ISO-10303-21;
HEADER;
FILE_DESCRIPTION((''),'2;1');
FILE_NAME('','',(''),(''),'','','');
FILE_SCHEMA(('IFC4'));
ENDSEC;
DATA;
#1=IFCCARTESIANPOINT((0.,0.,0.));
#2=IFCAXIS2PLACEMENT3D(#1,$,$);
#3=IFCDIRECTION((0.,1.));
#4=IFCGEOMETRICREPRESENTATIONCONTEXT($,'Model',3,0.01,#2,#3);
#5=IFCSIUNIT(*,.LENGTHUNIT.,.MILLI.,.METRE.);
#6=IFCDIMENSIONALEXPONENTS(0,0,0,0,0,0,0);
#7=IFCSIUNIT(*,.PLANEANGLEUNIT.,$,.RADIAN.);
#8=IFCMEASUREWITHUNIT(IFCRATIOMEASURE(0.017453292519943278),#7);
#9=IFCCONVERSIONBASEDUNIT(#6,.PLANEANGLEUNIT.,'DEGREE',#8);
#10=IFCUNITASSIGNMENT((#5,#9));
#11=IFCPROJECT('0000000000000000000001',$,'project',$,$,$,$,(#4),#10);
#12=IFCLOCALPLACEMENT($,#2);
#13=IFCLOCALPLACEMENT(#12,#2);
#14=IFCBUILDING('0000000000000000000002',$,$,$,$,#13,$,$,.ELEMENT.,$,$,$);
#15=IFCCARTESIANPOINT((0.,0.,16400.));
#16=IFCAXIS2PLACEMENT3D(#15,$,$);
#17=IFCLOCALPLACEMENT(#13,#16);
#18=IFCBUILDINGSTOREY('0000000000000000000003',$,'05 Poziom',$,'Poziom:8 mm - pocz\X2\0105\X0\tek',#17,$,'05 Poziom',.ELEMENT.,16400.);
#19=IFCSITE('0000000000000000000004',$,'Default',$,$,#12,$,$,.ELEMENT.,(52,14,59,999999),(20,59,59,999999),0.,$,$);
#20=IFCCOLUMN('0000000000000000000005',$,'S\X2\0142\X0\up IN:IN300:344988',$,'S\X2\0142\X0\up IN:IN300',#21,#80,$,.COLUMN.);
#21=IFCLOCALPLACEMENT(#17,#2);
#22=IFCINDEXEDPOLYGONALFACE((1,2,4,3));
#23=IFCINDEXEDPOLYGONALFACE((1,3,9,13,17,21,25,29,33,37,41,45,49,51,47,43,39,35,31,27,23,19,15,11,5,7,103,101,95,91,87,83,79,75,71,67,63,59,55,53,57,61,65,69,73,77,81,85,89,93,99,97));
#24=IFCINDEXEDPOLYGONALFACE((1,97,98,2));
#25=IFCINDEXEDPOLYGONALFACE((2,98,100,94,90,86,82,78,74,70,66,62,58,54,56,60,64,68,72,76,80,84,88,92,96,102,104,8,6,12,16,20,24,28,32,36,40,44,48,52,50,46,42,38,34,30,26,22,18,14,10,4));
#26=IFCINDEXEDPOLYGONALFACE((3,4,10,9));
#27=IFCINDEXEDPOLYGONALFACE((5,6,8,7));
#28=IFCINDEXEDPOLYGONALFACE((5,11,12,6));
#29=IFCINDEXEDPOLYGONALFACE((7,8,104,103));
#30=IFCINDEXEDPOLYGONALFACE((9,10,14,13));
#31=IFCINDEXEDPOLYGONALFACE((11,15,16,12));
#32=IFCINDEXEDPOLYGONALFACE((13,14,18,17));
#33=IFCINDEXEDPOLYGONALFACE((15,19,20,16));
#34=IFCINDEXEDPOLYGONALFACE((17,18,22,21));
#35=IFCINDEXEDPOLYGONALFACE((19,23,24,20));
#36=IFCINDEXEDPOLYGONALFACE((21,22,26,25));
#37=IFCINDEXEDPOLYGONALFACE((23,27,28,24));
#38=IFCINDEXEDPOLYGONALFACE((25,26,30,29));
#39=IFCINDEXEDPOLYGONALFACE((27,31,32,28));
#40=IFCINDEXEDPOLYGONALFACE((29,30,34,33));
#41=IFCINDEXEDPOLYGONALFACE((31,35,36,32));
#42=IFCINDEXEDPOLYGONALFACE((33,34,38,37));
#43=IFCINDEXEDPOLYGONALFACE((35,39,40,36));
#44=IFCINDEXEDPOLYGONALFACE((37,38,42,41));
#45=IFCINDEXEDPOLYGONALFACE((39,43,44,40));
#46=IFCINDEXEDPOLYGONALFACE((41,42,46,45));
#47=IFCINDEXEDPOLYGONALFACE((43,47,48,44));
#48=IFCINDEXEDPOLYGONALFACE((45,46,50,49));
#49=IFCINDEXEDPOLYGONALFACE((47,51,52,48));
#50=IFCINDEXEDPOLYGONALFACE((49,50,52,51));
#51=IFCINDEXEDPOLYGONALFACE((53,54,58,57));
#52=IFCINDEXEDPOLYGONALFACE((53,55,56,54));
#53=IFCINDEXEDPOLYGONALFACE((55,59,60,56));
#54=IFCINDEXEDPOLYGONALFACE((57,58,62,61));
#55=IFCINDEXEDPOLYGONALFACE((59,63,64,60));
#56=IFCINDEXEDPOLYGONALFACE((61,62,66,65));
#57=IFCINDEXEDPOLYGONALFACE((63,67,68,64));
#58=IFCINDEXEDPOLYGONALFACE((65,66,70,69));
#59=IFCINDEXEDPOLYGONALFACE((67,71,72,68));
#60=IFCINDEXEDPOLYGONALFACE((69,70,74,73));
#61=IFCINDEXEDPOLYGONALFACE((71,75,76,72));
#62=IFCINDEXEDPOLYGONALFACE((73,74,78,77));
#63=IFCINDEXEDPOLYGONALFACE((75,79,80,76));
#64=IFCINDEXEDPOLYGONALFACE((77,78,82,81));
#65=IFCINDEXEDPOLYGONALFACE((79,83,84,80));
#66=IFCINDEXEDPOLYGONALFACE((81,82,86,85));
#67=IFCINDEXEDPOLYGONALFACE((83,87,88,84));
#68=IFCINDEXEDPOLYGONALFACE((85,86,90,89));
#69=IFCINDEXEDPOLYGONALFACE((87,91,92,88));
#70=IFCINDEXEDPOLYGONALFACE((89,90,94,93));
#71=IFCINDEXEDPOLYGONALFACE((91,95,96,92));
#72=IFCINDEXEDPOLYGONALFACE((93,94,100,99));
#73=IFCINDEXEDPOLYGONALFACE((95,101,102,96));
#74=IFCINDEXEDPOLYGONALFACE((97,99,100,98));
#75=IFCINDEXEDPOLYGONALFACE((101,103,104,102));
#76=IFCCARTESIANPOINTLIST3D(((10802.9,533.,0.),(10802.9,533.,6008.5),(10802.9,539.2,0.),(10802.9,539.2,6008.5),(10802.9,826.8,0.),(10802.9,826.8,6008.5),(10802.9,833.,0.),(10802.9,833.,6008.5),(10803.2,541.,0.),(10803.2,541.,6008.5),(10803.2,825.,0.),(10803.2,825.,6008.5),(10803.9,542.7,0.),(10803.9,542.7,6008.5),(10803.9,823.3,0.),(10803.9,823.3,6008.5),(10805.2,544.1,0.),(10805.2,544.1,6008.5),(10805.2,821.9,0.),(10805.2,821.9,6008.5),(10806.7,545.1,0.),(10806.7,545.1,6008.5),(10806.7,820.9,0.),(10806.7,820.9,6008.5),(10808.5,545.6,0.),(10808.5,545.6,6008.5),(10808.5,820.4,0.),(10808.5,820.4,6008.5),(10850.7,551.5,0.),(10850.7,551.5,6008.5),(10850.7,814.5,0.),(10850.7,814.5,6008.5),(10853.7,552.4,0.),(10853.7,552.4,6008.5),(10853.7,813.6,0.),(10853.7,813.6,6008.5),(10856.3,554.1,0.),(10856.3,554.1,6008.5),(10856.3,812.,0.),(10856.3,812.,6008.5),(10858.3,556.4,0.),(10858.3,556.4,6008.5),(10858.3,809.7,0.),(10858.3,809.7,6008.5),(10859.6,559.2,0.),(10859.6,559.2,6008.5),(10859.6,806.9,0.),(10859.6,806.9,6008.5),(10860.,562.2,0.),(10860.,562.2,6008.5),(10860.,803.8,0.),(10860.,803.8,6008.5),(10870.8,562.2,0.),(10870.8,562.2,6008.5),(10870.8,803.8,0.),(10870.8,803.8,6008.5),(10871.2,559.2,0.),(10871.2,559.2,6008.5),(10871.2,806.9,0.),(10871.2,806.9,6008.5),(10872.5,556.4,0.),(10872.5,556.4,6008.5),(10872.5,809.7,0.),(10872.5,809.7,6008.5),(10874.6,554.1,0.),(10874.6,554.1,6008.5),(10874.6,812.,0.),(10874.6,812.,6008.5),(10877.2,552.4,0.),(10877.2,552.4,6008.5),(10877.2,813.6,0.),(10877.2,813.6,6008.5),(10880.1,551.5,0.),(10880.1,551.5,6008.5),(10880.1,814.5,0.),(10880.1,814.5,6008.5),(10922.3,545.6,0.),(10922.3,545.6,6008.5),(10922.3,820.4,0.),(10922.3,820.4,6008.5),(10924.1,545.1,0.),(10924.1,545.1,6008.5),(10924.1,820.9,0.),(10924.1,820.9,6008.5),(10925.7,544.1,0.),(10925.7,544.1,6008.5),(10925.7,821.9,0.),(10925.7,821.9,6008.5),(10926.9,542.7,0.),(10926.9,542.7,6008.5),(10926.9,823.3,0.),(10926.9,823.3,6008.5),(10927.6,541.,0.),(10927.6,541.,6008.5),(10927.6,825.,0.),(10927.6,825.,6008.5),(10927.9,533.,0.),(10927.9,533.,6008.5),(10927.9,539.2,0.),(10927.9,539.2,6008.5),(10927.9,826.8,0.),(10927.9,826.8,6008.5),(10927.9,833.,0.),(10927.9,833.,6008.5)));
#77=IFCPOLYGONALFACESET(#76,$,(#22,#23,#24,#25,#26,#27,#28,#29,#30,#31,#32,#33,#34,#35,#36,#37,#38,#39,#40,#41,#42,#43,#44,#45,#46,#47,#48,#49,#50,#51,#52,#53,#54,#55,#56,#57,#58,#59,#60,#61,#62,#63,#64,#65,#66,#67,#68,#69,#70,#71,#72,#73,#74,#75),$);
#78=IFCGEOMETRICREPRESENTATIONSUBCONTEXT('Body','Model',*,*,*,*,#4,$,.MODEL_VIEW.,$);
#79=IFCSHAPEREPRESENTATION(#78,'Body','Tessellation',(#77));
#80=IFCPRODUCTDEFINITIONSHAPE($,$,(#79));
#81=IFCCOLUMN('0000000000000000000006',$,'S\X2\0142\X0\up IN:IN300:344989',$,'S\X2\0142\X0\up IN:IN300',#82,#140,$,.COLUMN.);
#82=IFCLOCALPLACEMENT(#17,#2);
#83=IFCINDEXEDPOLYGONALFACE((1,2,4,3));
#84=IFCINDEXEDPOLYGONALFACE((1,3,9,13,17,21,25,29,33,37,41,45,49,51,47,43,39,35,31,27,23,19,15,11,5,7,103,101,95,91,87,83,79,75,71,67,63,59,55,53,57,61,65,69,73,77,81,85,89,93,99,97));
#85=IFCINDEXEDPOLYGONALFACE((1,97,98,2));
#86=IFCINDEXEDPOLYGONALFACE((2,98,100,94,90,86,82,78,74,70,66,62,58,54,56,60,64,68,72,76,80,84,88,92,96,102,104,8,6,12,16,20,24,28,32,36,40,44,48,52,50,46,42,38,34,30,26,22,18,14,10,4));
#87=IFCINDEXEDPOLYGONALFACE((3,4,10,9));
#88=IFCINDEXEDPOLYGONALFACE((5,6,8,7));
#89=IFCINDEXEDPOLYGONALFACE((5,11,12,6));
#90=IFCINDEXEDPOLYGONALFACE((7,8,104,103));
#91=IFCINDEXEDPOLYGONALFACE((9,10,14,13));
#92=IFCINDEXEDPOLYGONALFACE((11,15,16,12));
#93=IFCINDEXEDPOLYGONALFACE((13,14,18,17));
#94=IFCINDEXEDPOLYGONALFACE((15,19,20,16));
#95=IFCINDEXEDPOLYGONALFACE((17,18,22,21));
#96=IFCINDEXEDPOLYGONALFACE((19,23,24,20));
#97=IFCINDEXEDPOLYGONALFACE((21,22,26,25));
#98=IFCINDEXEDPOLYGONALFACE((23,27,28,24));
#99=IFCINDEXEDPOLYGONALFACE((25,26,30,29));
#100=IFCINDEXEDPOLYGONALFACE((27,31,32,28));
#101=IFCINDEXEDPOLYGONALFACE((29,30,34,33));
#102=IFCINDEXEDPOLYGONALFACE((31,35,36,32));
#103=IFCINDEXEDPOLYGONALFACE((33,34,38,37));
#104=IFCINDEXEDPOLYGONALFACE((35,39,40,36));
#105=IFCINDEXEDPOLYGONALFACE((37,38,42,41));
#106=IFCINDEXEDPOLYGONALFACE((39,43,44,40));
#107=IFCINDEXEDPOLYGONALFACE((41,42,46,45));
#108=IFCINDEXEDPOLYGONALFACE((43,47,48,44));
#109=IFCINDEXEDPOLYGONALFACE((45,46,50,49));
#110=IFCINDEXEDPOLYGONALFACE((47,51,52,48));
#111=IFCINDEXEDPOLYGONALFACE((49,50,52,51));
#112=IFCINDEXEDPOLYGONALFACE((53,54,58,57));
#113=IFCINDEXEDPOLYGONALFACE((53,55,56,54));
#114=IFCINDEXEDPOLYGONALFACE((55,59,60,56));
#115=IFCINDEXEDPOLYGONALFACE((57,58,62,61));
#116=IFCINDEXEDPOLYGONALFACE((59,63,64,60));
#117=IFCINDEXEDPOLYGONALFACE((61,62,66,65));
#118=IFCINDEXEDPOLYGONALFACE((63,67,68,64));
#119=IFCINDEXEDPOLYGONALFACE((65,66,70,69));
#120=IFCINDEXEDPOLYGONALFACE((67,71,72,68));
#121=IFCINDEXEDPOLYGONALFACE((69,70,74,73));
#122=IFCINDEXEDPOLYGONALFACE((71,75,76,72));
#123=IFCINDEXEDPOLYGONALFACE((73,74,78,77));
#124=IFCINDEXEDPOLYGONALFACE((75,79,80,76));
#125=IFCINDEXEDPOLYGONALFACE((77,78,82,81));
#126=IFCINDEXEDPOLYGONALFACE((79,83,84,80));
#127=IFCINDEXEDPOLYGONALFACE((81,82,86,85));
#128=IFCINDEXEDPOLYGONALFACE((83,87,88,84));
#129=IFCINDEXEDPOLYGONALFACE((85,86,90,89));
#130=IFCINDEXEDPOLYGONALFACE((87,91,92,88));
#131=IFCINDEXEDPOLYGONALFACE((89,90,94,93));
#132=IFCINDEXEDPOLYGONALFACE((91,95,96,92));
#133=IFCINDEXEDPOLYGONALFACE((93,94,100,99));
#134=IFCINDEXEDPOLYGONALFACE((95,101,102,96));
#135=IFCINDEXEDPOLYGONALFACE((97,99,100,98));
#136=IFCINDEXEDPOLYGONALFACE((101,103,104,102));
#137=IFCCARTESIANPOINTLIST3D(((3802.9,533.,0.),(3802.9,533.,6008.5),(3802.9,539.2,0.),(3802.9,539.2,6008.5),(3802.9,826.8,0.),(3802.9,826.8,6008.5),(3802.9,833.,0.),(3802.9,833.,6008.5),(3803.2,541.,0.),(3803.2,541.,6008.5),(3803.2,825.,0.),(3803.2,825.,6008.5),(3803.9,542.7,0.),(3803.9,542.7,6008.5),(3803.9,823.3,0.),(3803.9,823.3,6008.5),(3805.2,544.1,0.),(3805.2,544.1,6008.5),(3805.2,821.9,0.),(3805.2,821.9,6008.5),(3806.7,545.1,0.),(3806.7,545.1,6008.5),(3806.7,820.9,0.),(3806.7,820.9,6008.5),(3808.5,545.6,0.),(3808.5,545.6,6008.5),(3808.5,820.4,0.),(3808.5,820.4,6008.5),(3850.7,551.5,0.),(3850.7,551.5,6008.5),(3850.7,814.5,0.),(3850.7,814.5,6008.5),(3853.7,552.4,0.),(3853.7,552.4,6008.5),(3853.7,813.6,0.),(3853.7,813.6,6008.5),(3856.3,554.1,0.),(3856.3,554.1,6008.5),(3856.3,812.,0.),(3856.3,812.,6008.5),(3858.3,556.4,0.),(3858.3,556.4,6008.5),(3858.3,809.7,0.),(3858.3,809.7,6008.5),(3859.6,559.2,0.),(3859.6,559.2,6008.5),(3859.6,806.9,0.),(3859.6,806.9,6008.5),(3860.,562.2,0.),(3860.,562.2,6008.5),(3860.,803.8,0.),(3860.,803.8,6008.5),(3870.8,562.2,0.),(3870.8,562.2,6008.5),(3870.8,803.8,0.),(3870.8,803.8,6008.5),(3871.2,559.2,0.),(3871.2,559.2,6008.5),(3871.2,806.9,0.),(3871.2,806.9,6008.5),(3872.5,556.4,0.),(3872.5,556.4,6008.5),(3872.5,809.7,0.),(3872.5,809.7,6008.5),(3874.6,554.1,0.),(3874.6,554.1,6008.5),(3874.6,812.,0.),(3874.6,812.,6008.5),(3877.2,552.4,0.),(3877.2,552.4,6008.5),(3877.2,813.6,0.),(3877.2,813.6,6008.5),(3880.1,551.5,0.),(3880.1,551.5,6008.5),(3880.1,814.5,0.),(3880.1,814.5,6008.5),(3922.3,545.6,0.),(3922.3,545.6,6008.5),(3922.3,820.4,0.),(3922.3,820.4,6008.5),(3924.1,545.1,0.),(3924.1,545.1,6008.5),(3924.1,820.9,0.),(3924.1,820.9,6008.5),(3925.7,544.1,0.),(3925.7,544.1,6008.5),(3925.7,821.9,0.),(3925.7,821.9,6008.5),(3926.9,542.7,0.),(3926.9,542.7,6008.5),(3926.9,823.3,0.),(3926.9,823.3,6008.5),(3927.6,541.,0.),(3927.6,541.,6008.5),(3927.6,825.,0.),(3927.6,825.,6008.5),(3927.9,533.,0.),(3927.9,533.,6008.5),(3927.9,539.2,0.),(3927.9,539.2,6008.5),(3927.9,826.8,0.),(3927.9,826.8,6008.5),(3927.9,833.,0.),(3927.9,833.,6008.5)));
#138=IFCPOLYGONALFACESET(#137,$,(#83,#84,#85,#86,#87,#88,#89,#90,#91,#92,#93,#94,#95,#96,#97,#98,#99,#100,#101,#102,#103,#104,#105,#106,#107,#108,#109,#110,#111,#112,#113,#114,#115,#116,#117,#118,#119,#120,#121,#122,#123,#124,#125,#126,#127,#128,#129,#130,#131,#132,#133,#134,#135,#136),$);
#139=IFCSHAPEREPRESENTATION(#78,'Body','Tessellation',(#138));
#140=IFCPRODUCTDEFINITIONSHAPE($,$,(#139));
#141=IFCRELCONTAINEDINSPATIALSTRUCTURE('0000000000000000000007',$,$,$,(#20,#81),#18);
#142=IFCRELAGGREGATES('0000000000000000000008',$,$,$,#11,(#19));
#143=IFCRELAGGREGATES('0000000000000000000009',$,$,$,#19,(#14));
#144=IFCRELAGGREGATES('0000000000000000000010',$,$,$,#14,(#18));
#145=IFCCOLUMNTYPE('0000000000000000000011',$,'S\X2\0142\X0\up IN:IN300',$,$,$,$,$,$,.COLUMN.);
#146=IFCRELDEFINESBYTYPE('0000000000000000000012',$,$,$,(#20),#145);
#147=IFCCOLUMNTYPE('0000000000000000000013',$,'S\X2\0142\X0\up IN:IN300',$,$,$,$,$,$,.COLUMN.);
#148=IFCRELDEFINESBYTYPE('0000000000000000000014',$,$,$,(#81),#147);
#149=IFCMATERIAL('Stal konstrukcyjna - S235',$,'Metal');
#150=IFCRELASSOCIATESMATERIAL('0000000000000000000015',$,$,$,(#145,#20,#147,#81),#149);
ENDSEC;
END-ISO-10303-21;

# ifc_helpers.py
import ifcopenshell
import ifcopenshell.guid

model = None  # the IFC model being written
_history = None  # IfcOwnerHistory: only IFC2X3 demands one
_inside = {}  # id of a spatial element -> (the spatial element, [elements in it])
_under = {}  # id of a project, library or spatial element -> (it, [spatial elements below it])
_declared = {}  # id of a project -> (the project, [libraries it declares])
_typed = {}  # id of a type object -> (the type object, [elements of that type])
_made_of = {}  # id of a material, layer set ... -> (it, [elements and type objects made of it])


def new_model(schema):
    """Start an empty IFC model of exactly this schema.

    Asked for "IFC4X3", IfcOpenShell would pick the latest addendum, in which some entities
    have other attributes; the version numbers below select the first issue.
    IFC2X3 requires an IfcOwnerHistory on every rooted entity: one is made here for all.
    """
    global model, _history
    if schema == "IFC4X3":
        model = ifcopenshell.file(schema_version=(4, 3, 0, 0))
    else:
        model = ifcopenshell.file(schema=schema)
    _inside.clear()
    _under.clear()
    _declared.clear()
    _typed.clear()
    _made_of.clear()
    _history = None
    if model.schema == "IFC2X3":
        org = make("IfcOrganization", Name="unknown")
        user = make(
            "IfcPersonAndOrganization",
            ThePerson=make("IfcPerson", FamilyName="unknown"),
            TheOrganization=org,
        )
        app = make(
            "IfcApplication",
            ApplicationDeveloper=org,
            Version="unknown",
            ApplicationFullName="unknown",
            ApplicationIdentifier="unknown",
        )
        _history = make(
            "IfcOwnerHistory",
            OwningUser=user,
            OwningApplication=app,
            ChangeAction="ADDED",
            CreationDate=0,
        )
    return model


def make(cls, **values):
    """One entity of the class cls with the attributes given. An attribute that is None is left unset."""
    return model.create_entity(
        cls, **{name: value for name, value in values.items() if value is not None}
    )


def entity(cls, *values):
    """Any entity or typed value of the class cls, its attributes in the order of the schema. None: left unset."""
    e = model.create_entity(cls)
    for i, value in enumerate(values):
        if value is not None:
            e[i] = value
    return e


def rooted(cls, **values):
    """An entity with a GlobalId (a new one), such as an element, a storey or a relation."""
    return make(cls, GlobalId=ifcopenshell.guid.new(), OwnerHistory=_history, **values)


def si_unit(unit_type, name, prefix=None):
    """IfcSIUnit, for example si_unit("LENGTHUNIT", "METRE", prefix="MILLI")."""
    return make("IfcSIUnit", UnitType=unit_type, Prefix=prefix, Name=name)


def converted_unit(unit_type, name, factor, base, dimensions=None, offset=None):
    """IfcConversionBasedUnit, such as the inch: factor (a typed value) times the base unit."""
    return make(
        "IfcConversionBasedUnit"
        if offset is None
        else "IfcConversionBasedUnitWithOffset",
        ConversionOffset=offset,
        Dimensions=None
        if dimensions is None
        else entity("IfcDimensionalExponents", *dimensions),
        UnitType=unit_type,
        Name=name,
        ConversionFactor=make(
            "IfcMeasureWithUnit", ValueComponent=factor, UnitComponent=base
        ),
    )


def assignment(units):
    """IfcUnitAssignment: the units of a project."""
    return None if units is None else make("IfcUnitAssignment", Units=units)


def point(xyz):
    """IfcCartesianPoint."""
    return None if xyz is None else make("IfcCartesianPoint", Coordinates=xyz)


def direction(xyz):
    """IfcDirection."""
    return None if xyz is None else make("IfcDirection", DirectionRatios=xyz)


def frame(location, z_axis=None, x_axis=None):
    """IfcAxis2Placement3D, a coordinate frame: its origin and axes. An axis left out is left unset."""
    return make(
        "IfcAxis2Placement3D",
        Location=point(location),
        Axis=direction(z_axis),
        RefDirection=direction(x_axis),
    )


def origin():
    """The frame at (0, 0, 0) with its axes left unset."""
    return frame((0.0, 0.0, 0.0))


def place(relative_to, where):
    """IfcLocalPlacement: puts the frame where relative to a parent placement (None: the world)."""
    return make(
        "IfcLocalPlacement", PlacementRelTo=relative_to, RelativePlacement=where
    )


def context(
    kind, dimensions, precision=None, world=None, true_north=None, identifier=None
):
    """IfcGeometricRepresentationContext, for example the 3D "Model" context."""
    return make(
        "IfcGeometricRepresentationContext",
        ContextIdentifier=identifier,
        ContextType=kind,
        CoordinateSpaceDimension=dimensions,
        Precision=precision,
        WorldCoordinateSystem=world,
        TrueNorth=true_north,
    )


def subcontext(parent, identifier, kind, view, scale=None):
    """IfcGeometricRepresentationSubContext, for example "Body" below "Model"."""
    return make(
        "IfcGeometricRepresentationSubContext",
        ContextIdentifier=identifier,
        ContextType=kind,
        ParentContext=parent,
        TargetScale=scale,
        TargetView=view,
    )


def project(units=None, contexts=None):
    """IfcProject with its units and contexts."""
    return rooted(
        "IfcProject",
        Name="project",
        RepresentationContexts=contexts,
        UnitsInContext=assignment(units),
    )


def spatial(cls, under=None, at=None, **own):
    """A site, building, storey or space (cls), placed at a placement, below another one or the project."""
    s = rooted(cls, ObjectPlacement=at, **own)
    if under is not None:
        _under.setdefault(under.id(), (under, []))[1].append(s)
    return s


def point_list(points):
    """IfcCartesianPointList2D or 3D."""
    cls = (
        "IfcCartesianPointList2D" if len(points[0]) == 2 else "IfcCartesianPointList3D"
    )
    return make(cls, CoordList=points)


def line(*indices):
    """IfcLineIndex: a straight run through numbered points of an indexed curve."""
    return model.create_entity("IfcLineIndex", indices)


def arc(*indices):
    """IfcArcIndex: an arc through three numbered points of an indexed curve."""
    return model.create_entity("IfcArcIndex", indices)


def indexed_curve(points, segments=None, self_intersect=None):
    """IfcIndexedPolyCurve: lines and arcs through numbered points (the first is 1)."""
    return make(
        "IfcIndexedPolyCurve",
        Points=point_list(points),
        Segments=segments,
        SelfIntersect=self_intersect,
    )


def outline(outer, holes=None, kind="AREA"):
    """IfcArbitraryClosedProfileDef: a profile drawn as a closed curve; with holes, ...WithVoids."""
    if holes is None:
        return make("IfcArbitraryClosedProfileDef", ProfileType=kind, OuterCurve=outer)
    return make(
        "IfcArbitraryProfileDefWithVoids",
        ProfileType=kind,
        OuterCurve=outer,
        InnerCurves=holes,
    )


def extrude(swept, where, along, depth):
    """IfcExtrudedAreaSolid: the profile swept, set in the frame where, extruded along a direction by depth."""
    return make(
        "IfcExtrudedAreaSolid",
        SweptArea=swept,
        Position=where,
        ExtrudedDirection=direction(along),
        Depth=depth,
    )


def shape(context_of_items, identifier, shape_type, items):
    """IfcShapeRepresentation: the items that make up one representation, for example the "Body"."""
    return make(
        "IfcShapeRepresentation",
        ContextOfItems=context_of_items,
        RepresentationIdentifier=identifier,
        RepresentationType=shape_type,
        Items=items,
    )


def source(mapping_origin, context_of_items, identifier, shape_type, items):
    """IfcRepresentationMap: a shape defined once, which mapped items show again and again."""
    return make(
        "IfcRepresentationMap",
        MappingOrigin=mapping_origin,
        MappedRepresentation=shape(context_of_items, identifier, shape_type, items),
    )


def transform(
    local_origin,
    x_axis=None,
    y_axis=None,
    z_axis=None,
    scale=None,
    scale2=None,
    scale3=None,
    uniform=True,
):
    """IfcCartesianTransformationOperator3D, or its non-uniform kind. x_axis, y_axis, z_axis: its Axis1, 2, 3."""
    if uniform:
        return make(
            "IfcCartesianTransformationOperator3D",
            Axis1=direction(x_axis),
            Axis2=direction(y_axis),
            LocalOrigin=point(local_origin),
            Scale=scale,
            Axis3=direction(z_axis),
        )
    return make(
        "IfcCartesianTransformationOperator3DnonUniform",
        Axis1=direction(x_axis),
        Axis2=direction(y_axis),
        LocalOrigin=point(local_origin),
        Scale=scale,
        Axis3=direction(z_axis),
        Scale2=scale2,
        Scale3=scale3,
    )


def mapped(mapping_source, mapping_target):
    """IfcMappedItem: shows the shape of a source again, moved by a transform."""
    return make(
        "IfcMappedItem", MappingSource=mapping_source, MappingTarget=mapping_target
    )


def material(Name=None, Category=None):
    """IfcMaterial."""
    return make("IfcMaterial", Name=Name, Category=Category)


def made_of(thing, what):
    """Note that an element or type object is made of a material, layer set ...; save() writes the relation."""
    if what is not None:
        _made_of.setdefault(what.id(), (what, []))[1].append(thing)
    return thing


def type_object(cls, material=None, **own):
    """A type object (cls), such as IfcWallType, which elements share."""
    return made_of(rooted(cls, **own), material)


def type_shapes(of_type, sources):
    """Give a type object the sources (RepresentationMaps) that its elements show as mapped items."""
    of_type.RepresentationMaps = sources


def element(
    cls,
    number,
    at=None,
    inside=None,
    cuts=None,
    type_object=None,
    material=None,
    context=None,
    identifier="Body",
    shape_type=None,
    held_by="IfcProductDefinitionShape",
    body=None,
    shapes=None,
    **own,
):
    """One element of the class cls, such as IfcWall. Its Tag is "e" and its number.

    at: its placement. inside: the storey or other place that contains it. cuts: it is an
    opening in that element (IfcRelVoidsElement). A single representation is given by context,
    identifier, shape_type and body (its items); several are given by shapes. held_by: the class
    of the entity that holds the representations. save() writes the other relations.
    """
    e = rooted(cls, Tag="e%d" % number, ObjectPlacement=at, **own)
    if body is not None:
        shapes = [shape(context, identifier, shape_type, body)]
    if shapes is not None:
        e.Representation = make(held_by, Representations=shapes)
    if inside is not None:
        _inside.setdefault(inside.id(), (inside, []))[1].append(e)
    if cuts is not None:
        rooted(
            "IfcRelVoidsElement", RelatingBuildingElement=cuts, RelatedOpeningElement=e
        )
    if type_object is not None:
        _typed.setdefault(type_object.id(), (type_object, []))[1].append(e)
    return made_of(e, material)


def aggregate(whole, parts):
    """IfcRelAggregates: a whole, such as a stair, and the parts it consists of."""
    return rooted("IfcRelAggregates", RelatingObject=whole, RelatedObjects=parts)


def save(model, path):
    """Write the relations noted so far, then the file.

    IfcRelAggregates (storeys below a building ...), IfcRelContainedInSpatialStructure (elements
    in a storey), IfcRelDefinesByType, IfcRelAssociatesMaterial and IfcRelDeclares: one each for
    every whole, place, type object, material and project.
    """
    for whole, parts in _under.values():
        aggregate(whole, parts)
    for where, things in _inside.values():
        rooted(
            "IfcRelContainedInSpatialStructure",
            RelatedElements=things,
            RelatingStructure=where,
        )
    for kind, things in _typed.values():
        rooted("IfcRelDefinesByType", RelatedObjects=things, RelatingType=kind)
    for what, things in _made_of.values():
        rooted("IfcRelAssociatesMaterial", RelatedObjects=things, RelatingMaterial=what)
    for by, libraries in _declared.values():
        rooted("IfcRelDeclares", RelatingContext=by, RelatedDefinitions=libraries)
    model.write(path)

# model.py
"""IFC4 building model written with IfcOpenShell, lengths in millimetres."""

from ifc_helpers import new_model, entity, si_unit, converted_unit, direction, frame, origin, place, context, subcontext, project, spatial, line, arc, indexed_curve, outline, extrude, source, transform, mapped, material, type_object, type_shapes, element, save


model = new_model("IFC4")

# Units and contexts
model_context = context("Model", 3, precision=0.01, world=origin(), true_north=direction((0.0, 1.0)))
body_context = subcontext(model_context, "Body", "Model", "MODEL_VIEW")
ifc_project = project(units=[si_unit("LENGTHUNIT", "METRE", prefix="MILLI"), converted_unit("PLANEANGLEUNIT", "DEGREE", entity("IfcRatioMeasure", 0.017453292519943278), si_unit("PLANEANGLEUNIT", "RADIAN"), dimensions=[0, 0, 0, 0, 0, 0, 0])], contexts=[model_context])

# Site, building, storey
site_placement = place(None, origin())
site = spatial("IfcSite", under=ifc_project, at=site_placement, Name="Default", CompositionType="ELEMENT", RefLatitude=(52, 14, 59, 999999), RefLongitude=(20, 59, 59, 999999), RefElevation=0.0)
building_placement = place(site_placement, origin())
building = spatial("IfcBuilding", under=site, at=building_placement, CompositionType="ELEMENT")
storey_placement = place(building_placement, frame((0.0, 0.0, 16400.0)))
storey = spatial("IfcBuildingStorey", under=building, at=storey_placement, Name="05 Poziom", ObjectType="Poziom:8 mm - początek", LongName="05 Poziom", CompositionType="ELEMENT", Elevation=16400.0)

# Columns
ifc_material = material(Name="Stal konstrukcyjna - S235", Category="Metal")
column_type_1 = type_object("IfcColumnType", Name="Słup IN:IN300", PredefinedType="COLUMN", material=ifc_material)
shared_shape_1 = source(origin(), body_context, "Body", "SweptSolid", [
    extrude(outline(indexed_curve([(143.8, -62.5), (150.0, -62.5), (150.0, 62.5), (143.8, 62.5), (139.6, 60.9), (137.4, 56.9), (131.5, 14.7), (127.9, 8.1), (120.8, 5.4), (-120.8, 5.4), (-127.9, 8.1), (-131.5, 14.7), (-137.4, 56.9), (-139.6, 60.9), (-143.8, 62.5), (-150.0, 62.5), (-150.0, -62.5), (-143.8, -62.5), (-139.6, -60.9), (-137.4, -56.9), (-131.5, -14.7), (-127.9, -8.1), (-120.8, -5.4), (120.8, -5.4), (127.9, -8.1), (131.5, -14.7), (137.4, -56.9), (139.6, -60.9)], segments=[line(1, 2, 3, 4), arc(4, 5, 6), line(6, 7), arc(7, 8, 9), line(9, 10), arc(10, 11, 12), line(12, 13), arc(13, 14, 15), line(15, 16, 17, 18), arc(18, 19, 20), line(20, 21), arc(21, 22, 23), line(23, 24), arc(24, 25, 26), line(26, 27), arc(27, 28, 1)], self_intersect=False)), frame((10865.4, 683.0, 16400.0), z_axis=(0.0, 0.0, 1.0), x_axis=(0.0, -1.0, 0.0)), (0.0, 0.0, 1.0), 6008.5),
])
type_shapes(column_type_1, [shared_shape_1])
column_1_placement = place(storey_placement, frame((0.0, 0.0, -16400.0)))
element("IfcColumn", 1, at=column_1_placement, inside=storey, type_object=column_type_1, material=ifc_material, Name="Słup IN:IN300:344988", ObjectType="Słup IN:IN300", PredefinedType="COLUMN", context=body_context, shape_type="MappedRepresentation", body=[
    mapped(shared_shape_1, transform((0.0, 0.0, 0.0), scale=1.0)),
])
column_type_2 = type_object("IfcColumnType", Name="Słup IN:IN300", PredefinedType="COLUMN", material=ifc_material)
shared_shape_2 = source(origin(), body_context, "Body", "SweptSolid", [
    extrude(outline(indexed_curve([(143.8, -62.5), (150.0, -62.5), (150.0, 62.5), (143.8, 62.5), (139.6, 60.9), (137.4, 56.9), (131.5, 14.7), (127.9, 8.1), (120.8, 5.4), (-120.8, 5.4), (-127.9, 8.1), (-131.5, 14.7), (-137.4, 56.9), (-139.6, 60.9), (-143.8, 62.5), (-150.0, 62.5), (-150.0, -62.5), (-143.8, -62.5), (-139.6, -60.9), (-137.4, -56.9), (-131.5, -14.7), (-127.9, -8.1), (-120.8, -5.4), (120.8, -5.4), (127.9, -8.1), (131.5, -14.7), (137.4, -56.9), (139.6, -60.9)], segments=[line(1, 2, 3, 4), arc(4, 5, 6), line(6, 7), arc(7, 8, 9), line(9, 10), arc(10, 11, 12), line(12, 13), arc(13, 14, 15), line(15, 16, 17, 18), arc(18, 19, 20), line(20, 21), arc(21, 22, 23), line(23, 24), arc(24, 25, 26), line(26, 27), arc(27, 28, 1)], self_intersect=False)), frame((3865.4, 683.0, 16400.0), z_axis=(0.0, 0.0, 1.0), x_axis=(0.0, -1.0, 0.0)), (0.0, 0.0, 1.0), 6008.5),
])
type_shapes(column_type_2, [shared_shape_2])
column_2_placement = place(storey_placement, frame((0.0, 0.0, -16400.0)))
element("IfcColumn", 2, at=column_2_placement, inside=storey, type_object=column_type_2, material=ifc_material, Name="Słup IN:IN300:344989", ObjectType="Słup IN:IN300", PredefinedType="COLUMN", context=body_context, shape_type="MappedRepresentation", body=[
    mapped(shared_shape_2, transform((0.0, 0.0, 0.0), scale=1.0)),
])

save(model, "model.ifc")
